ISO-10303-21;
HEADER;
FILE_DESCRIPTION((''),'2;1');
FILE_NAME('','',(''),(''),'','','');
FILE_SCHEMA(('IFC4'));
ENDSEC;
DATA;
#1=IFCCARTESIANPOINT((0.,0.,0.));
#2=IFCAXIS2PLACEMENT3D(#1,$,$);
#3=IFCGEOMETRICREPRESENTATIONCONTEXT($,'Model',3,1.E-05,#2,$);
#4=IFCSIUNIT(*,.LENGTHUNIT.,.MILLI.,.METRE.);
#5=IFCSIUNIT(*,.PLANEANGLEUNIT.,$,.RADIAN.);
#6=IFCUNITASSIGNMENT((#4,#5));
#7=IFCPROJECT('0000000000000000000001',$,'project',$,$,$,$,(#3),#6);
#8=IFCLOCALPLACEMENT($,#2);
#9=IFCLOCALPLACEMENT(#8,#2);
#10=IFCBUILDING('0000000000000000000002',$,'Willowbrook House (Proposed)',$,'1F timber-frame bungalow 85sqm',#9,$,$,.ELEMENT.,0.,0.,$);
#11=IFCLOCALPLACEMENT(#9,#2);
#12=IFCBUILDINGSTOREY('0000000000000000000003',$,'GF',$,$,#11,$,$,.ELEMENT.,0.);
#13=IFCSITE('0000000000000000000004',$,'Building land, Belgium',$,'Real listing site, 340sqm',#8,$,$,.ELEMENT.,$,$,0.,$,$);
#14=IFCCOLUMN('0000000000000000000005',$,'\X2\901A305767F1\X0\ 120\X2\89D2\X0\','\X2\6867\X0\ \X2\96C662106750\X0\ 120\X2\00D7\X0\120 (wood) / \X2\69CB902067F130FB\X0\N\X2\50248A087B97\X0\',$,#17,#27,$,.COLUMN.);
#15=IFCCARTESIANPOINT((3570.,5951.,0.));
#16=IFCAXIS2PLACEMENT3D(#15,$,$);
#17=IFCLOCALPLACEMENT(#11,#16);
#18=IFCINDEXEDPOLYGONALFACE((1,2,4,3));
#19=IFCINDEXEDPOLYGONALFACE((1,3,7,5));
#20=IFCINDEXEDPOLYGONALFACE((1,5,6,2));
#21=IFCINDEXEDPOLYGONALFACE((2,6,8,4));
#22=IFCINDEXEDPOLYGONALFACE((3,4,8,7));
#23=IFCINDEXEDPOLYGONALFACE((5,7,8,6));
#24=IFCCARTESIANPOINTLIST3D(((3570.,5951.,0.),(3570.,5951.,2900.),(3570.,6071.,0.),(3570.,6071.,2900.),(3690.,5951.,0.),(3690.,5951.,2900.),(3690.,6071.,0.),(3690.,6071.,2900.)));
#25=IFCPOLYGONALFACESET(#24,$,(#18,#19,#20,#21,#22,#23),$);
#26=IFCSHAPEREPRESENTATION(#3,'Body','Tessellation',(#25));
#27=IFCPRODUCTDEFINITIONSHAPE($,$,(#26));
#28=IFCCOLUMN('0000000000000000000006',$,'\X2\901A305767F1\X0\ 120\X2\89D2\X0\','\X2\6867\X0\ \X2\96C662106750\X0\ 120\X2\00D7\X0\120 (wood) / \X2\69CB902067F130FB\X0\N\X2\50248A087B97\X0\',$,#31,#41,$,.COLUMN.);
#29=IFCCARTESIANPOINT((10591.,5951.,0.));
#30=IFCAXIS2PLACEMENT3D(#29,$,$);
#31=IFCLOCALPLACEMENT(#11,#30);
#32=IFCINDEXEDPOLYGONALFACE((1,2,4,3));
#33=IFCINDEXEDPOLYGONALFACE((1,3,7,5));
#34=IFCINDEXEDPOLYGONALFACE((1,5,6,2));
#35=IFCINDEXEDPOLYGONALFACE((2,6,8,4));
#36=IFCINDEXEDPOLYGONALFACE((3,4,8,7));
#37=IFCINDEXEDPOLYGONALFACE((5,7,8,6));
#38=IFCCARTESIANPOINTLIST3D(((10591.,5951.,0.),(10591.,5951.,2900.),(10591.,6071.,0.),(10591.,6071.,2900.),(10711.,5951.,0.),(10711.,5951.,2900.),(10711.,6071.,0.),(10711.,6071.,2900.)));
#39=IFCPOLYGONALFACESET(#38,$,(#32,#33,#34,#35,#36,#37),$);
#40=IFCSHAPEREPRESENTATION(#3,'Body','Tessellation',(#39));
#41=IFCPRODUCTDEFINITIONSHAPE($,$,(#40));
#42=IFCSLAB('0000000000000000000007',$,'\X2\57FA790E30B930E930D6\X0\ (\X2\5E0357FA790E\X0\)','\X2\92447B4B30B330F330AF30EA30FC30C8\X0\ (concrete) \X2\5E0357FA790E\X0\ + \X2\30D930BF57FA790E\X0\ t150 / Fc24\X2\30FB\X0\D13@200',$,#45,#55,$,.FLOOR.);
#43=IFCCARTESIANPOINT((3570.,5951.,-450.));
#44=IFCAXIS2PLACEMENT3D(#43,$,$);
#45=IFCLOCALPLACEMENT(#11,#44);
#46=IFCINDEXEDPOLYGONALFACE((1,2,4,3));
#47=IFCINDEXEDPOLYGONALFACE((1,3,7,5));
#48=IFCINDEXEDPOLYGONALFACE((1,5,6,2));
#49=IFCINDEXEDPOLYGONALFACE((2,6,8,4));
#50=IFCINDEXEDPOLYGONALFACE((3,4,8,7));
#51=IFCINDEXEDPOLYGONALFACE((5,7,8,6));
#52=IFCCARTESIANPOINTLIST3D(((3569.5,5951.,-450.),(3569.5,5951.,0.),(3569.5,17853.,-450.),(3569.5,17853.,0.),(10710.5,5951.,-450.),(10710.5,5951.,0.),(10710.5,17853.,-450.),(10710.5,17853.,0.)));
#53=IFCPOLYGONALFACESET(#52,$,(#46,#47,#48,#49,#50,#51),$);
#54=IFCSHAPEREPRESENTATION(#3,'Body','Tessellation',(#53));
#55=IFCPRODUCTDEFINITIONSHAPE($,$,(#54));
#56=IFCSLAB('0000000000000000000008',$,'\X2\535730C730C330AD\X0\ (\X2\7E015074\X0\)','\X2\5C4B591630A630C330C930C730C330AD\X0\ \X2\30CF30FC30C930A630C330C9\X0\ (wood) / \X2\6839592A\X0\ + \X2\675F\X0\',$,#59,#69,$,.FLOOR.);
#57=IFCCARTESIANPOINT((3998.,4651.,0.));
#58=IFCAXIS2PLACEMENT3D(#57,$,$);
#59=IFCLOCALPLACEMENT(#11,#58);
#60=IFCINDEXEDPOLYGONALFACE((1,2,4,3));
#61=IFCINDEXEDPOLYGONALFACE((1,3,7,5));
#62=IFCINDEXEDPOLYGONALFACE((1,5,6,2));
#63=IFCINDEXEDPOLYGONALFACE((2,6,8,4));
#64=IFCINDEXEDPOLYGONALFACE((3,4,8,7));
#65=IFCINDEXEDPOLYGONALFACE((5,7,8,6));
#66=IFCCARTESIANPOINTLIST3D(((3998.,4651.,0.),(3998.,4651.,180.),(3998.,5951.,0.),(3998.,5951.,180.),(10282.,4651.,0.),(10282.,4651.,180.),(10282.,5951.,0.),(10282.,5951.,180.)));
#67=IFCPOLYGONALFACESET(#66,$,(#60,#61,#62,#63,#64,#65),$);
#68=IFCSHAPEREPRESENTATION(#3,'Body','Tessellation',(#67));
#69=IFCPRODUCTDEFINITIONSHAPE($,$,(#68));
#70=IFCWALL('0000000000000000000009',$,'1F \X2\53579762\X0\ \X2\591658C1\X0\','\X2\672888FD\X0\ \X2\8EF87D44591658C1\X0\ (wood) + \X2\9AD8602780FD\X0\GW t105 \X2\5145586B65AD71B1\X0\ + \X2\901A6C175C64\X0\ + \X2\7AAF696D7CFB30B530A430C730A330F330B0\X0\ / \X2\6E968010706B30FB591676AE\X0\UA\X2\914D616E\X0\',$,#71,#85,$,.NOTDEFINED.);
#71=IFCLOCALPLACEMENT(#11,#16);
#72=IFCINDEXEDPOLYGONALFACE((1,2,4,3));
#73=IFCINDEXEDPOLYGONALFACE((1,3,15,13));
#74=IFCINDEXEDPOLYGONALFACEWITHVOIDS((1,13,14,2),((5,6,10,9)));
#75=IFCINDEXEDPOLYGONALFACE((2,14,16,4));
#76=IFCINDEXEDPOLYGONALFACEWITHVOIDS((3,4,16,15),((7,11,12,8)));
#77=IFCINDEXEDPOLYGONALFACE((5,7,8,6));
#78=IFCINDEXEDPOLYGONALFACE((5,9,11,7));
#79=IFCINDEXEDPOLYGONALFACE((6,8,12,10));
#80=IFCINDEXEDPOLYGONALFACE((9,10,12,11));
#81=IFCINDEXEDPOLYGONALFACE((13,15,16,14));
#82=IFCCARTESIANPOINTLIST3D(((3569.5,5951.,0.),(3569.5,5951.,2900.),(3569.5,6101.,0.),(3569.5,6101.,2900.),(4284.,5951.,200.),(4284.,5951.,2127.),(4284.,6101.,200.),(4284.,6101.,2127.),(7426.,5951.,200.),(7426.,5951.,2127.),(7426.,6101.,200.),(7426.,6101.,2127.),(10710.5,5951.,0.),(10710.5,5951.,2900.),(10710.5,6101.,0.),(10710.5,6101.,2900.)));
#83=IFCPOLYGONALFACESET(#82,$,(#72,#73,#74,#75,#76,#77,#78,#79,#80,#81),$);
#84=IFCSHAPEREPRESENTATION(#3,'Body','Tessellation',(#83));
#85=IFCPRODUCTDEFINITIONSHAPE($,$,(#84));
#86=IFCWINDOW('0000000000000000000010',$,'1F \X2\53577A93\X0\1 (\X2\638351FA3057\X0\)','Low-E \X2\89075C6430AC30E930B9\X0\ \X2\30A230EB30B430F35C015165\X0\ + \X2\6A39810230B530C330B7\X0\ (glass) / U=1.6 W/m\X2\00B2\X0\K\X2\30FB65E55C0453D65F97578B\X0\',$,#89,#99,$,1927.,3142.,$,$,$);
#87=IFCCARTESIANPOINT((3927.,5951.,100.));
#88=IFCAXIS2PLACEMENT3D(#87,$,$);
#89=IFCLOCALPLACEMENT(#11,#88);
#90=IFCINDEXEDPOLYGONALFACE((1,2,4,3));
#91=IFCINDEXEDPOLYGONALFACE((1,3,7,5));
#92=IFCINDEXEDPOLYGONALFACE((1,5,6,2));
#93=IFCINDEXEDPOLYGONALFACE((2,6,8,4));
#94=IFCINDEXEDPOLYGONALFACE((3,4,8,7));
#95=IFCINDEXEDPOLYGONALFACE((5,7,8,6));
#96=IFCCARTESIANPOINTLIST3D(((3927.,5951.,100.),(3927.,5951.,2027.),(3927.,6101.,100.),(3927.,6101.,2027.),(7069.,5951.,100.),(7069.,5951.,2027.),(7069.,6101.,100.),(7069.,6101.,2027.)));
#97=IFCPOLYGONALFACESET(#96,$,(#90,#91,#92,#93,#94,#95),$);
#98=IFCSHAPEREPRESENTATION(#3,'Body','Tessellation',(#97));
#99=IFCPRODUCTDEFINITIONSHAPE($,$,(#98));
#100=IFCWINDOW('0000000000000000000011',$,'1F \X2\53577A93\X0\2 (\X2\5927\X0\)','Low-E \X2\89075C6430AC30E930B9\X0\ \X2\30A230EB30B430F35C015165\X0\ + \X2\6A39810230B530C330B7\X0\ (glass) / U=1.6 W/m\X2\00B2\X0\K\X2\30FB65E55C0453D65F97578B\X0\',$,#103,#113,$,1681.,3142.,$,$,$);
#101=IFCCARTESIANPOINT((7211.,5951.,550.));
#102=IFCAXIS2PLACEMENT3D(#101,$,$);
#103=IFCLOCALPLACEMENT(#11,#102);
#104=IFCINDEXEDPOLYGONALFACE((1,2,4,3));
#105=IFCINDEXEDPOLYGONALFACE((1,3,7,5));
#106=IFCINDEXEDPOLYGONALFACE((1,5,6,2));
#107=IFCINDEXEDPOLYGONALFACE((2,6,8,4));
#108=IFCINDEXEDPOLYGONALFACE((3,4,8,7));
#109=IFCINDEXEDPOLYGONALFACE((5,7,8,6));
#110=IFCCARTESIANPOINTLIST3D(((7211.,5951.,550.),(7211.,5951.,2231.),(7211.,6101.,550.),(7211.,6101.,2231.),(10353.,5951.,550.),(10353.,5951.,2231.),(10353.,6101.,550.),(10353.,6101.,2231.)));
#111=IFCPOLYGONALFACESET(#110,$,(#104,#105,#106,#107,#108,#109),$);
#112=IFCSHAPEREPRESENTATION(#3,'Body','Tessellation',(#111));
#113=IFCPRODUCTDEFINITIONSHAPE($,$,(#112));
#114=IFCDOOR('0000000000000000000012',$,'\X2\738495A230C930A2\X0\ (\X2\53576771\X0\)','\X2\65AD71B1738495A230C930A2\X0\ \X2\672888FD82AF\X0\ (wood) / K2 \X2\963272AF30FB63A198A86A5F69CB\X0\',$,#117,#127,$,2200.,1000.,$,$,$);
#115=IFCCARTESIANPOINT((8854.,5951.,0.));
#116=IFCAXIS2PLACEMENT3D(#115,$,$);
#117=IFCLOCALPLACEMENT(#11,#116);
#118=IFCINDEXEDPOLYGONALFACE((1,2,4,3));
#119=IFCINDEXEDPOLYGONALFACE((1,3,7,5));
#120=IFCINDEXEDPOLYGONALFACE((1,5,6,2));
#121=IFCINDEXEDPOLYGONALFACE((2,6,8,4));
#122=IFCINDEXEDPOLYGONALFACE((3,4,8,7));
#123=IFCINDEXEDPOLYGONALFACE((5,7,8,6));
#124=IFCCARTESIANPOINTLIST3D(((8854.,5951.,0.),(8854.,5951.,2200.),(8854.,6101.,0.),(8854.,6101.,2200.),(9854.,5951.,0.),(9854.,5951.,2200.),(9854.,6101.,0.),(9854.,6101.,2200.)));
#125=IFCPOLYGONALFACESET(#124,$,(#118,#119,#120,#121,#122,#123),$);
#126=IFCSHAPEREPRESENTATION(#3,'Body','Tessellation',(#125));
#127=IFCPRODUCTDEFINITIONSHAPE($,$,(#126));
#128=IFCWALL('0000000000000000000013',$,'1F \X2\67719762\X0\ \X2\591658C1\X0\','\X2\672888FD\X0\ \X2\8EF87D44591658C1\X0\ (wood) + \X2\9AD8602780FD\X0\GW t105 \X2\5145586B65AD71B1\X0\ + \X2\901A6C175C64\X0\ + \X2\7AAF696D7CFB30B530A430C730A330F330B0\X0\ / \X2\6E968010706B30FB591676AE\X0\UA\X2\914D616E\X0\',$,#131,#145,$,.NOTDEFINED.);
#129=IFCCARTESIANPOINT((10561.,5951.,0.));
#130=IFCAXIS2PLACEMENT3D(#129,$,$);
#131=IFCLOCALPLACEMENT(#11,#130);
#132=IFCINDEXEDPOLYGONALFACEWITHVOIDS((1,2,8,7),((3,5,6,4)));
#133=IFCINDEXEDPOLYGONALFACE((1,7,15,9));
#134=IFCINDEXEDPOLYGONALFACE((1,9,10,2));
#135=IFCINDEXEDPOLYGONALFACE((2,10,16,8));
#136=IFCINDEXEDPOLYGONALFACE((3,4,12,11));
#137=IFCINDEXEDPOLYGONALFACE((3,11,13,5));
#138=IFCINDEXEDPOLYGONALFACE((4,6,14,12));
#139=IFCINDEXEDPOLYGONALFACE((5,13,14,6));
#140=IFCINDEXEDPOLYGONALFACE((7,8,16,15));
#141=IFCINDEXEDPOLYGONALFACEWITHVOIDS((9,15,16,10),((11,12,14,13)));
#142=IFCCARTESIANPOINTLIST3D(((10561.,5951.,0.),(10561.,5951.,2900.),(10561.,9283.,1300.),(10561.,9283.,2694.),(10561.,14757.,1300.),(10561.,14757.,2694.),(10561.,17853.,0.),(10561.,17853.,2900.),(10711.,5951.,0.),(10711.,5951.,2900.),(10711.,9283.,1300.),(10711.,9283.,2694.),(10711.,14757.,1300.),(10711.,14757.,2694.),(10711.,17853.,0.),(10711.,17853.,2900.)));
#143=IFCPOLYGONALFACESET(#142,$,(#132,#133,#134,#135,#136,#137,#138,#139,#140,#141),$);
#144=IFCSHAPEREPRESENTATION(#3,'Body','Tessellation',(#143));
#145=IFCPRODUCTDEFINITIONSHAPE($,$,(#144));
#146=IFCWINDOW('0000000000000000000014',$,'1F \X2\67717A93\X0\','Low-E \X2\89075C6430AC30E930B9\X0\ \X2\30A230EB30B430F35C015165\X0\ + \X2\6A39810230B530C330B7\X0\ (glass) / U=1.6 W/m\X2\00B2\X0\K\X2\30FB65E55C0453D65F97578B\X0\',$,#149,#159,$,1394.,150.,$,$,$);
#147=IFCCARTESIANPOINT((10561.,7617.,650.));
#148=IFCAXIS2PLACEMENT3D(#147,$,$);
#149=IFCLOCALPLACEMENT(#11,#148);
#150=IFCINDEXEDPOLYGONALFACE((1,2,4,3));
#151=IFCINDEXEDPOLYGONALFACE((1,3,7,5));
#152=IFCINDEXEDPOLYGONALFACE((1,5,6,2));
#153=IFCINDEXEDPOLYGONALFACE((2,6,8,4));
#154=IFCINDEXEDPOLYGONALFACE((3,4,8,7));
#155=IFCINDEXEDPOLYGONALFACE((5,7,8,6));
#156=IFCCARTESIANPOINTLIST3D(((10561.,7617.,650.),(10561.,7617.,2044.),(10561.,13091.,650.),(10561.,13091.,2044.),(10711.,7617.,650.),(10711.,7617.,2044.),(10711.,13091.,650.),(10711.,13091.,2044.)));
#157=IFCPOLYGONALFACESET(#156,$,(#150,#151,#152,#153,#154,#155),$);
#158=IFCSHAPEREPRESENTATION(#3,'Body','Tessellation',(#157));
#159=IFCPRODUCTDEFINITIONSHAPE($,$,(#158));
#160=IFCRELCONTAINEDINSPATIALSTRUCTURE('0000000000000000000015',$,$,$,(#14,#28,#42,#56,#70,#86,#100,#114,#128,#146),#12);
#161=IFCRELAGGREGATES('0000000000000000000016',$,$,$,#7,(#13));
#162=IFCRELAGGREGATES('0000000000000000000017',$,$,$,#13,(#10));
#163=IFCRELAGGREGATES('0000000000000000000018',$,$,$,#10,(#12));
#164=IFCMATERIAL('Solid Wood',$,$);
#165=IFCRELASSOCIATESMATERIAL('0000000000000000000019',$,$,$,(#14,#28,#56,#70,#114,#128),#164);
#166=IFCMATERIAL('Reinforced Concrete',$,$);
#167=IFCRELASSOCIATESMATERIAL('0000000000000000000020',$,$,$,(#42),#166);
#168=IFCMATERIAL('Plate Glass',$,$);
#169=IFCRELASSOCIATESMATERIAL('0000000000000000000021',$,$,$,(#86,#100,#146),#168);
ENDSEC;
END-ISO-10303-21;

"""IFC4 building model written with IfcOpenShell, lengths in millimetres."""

from ifc_helpers import new_model, si_unit, frame, frame_2d, origin, place, context, project, spatial, rectangle, extrude, material, element, fill, save


model = new_model("IFC4")

# Units and contexts
model_context = context("Model", 3, precision=1e-05, world=origin())
ifc_project = project(units=[si_unit("LENGTHUNIT", "METRE", prefix="MILLI"), si_unit("PLANEANGLEUNIT", "RADIAN")], contexts=[model_context])

# Site, building, storey
site_placement = place(None, origin())
site = spatial("IfcSite", under=ifc_project, at=site_placement, Name="Building land, Belgium", ObjectType="Real listing site, 340sqm", CompositionType="ELEMENT", RefElevation=0.0)
building_placement = place(site_placement, origin())
building = spatial("IfcBuilding", under=site, at=building_placement, Name="Willowbrook House (Proposed)", ObjectType="1F timber-frame bungalow 85sqm", CompositionType="ELEMENT", ElevationOfRefHeight=0.0, ElevationOfTerrain=0.0)
storey_placement = place(building_placement, origin())
storey = spatial("IfcBuildingStorey", under=building, at=storey_placement, Name="GF", CompositionType="ELEMENT", Elevation=0.0)

# Columns
ifc_material_1 = material(Name="Solid Wood")
column_1_placement = place(storey_placement, frame((3570.0, 5951.0, 0.0)))
element("IfcColumn", 1, at=column_1_placement, inside=storey, material=ifc_material_1, Name="通し柱 120角", Description="桧 集成材 120×120 (wood) / 構造柱・N値計算", PredefinedType="COLUMN", context=model_context, shape_type="SweptSolid", body=[
    extrude(rectangle(XDim=120.0, YDim=120.0, at=frame_2d((60.0, 60.0))), frame((3570.0, 5951.0, 0.0)), (0.0, 0.0, 1.0), 2900.0),
])
column_2_placement = place(storey_placement, frame((10591.0, 5951.0, 0.0)))
element("IfcColumn", 2, at=column_2_placement, inside=storey, material=ifc_material_1, Name="通し柱 120角", Description="桧 集成材 120×120 (wood) / 構造柱・N値計算", PredefinedType="COLUMN", context=model_context, shape_type="SweptSolid", body=[
    extrude(rectangle(XDim=120.0, YDim=120.0, at=frame_2d((60.0, 60.0))), frame((10591.0, 5951.0, 0.0)), (0.0, 0.0, 1.0), 2900.0),
])

# Slabs
ifc_material_2 = material(Name="Reinforced Concrete")
slab_1_placement = place(storey_placement, frame((3570.0, 5951.0, -450.0)))
element("IfcSlab", 3, at=slab_1_placement, inside=storey, material=ifc_material_2, Name="基礎スラブ (布基礎)", Description="鉄筋コンクリート (concrete) 布基礎 + ベタ基礎 t150 / Fc24・D13@200", PredefinedType="FLOOR", context=model_context, shape_type="SweptSolid", body=[
    extrude(rectangle(XDim=7141.0, YDim=11902.0, at=frame_2d((3570.0, 5951.0))), frame((3570.0, 5951.0, -450.0)), (0.0, 0.0, 1.0), 450.0),
])
slab_2_placement = place(storey_placement, frame((3998.0, 4651.0, 0.0)))
element("IfcSlab", 4, at=slab_2_placement, inside=storey, material=ifc_material_1, Name="南デッキ (縁側)", Description="屋外ウッドデッキ ハードウッド (wood) / 根太 + 束", PredefinedType="FLOOR", context=model_context, shape_type="SweptSolid", body=[
    extrude(rectangle(XDim=6284.0, YDim=1300.0, at=frame_2d((3142.0, 650.0))), frame((3998.0, 4651.0, 0.0)), (0.0, 0.0, 1.0), 180.0),
])

# Wall, openings, windows, door
wall_1_placement = place(storey_placement, frame((3570.0, 5951.0, 0.0)))
wall_1 = element("IfcWall", 5, at=wall_1_placement, inside=storey, material=ifc_material_1, Name="1F 南面 外壁", Description="木製 軸組外壁 (wood) + 高性能GW t105 充填断熱 + 通気層 + 窯業系サイディング / 準耐火・外皮UA配慮", PredefinedType="NOTDEFINED", context=model_context, shape_type="SweptSolid", body=[
    extrude(rectangle(XDim=7141.0, YDim=150.0, at=frame_2d((3570.0, 75.0))), frame((3570.0, 5951.0, 0.0)), (0.0, 0.0, 1.0), 2900.0),
])
opening_1_placement = place(storey_placement, frame((3927.0, 5951.0, 100.0)))
opening_1 = element("IfcOpeningElement", 6, at=opening_1_placement, cuts=wall_1, PredefinedType="NOTDEFINED", context=model_context, shape_type="SweptSolid", body=[
    extrude(rectangle(XDim=3142.0, YDim=150.0, at=frame_2d((1571.0, 75.0))), frame((3927.0, 5951.0, 100.0)), (0.0, 0.0, 1.0), 1927.0),
])
opening_2_placement = place(storey_placement, frame((7211.0, 5951.0, 550.0)))
opening_2 = element("IfcOpeningElement", 7, at=opening_2_placement, cuts=wall_1, PredefinedType="NOTDEFINED", context=model_context, shape_type="SweptSolid", body=[
    extrude(rectangle(XDim=3142.0, YDim=150.0, at=frame_2d((1571.0, 75.0))), frame((7211.0, 5951.0, 550.0)), (0.0, 0.0, 1.0), 1681.0),
])
opening_3_placement = place(storey_placement, frame((8854.0, 5951.0, 0.0)))
opening_3 = element("IfcOpeningElement", 8, at=opening_3_placement, cuts=wall_1, PredefinedType="NOTDEFINED", context=model_context, shape_type="SweptSolid", body=[
    extrude(rectangle(XDim=1000.0, YDim=150.0, at=frame_2d((500.0, 75.0))), frame((8854.0, 5951.0, 0.0)), (0.0, 0.0, 1.0), 2200.0),
])
ifc_material_3 = material(Name="Plate Glass")
window_1_placement = place(storey_placement, frame((3927.0, 5951.0, 100.0)))
window_1 = element("IfcWindow", 9, at=window_1_placement, inside=storey, material=ifc_material_3, Name="1F 南窓1 (掃出し)", Description="Low-E 複層ガラス アルゴン封入 + 樹脂サッシ (glass) / U=1.6 W/m²K・日射取得型", OverallHeight=1927.0, OverallWidth=3142.0, context=model_context, shape_type="SweptSolid", body=[
    extrude(rectangle(XDim=3142.0, YDim=150.0, at=frame_2d((1571.0, 75.0))), frame((3927.0, 5951.0, 100.0)), (0.0, 0.0, 1.0), 1927.0),
])
fill(opening_1, window_1)
window_2_placement = place(storey_placement, frame((7211.0, 5951.0, 550.0)))
window_2 = element("IfcWindow", 10, at=window_2_placement, inside=storey, material=ifc_material_3, Name="1F 南窓2 (大)", Description="Low-E 複層ガラス アルゴン封入 + 樹脂サッシ (glass) / U=1.6 W/m²K・日射取得型", OverallHeight=1681.0, OverallWidth=3142.0, context=model_context, shape_type="SweptSolid", body=[
    extrude(rectangle(XDim=3142.0, YDim=150.0, at=frame_2d((1571.0, 75.0))), frame((7211.0, 5951.0, 550.0)), (0.0, 0.0, 1.0), 1681.0),
])
fill(opening_2, window_2)
door_placement = place(storey_placement, frame((8854.0, 5951.0, 0.0)))
door = element("IfcDoor", 11, at=door_placement, inside=storey, material=ifc_material_1, Name="玄関ドア (南東)", Description="断熱玄関ドア 木製芯 (wood) / K2 防犯・採風機構", OverallHeight=2200.0, OverallWidth=1000.0, context=model_context, shape_type="SweptSolid", body=[
    extrude(rectangle(XDim=1000.0, YDim=150.0, at=frame_2d((500.0, 75.0))), frame((8854.0, 5951.0, 0.0)), (0.0, 0.0, 1.0), 2200.0),
])
fill(opening_3, door)

# Wall, opening, window
wall_2_placement = place(storey_placement, frame((10561.0, 5951.0, 0.0)))
wall_2 = element("IfcWall", 12, at=wall_2_placement, inside=storey, material=ifc_material_1, Name="1F 東面 外壁", Description="木製 軸組外壁 (wood) + 高性能GW t105 充填断熱 + 通気層 + 窯業系サイディング / 準耐火・外皮UA配慮", PredefinedType="NOTDEFINED", context=model_context, shape_type="SweptSolid", body=[
    extrude(rectangle(XDim=150.0, YDim=11902.0, at=frame_2d((75.0, 5951.0))), frame((10561.0, 5951.0, 0.0)), (0.0, 0.0, 1.0), 2900.0),
])
opening_4_placement = place(storey_placement, frame((10561.0, 7617.0, 650.0)))
opening_4 = element("IfcOpeningElement", 13, at=opening_4_placement, cuts=wall_2, PredefinedType="NOTDEFINED", context=model_context, shape_type="SweptSolid", body=[
    extrude(rectangle(XDim=150.0, YDim=5474.0, at=frame_2d((75.0, 2737.0))), frame((10561.0, 7617.0, 650.0)), (0.0, 0.0, 1.0), 1394.0),
])
window_3_placement = place(storey_placement, frame((10561.0, 7617.0, 650.0)))
window_3 = element("IfcWindow", 14, at=window_3_placement, inside=storey, material=ifc_material_3, Name="1F 東窓", Description="Low-E 複層ガラス アルゴン封入 + 樹脂サッシ (glass) / U=1.6 W/m²K・日射取得型", OverallHeight=1394.0, OverallWidth=150.0, context=model_context, shape_type="SweptSolid", body=[
    extrude(rectangle(XDim=150.0, YDim=5474.0, at=frame_2d((75.0, 2737.0))), frame((10561.0, 7617.0, 650.0)), (0.0, 0.0, 1.0), 1394.0),
])
fill(opening_4, window_3)

save(model, "model.ifc")
